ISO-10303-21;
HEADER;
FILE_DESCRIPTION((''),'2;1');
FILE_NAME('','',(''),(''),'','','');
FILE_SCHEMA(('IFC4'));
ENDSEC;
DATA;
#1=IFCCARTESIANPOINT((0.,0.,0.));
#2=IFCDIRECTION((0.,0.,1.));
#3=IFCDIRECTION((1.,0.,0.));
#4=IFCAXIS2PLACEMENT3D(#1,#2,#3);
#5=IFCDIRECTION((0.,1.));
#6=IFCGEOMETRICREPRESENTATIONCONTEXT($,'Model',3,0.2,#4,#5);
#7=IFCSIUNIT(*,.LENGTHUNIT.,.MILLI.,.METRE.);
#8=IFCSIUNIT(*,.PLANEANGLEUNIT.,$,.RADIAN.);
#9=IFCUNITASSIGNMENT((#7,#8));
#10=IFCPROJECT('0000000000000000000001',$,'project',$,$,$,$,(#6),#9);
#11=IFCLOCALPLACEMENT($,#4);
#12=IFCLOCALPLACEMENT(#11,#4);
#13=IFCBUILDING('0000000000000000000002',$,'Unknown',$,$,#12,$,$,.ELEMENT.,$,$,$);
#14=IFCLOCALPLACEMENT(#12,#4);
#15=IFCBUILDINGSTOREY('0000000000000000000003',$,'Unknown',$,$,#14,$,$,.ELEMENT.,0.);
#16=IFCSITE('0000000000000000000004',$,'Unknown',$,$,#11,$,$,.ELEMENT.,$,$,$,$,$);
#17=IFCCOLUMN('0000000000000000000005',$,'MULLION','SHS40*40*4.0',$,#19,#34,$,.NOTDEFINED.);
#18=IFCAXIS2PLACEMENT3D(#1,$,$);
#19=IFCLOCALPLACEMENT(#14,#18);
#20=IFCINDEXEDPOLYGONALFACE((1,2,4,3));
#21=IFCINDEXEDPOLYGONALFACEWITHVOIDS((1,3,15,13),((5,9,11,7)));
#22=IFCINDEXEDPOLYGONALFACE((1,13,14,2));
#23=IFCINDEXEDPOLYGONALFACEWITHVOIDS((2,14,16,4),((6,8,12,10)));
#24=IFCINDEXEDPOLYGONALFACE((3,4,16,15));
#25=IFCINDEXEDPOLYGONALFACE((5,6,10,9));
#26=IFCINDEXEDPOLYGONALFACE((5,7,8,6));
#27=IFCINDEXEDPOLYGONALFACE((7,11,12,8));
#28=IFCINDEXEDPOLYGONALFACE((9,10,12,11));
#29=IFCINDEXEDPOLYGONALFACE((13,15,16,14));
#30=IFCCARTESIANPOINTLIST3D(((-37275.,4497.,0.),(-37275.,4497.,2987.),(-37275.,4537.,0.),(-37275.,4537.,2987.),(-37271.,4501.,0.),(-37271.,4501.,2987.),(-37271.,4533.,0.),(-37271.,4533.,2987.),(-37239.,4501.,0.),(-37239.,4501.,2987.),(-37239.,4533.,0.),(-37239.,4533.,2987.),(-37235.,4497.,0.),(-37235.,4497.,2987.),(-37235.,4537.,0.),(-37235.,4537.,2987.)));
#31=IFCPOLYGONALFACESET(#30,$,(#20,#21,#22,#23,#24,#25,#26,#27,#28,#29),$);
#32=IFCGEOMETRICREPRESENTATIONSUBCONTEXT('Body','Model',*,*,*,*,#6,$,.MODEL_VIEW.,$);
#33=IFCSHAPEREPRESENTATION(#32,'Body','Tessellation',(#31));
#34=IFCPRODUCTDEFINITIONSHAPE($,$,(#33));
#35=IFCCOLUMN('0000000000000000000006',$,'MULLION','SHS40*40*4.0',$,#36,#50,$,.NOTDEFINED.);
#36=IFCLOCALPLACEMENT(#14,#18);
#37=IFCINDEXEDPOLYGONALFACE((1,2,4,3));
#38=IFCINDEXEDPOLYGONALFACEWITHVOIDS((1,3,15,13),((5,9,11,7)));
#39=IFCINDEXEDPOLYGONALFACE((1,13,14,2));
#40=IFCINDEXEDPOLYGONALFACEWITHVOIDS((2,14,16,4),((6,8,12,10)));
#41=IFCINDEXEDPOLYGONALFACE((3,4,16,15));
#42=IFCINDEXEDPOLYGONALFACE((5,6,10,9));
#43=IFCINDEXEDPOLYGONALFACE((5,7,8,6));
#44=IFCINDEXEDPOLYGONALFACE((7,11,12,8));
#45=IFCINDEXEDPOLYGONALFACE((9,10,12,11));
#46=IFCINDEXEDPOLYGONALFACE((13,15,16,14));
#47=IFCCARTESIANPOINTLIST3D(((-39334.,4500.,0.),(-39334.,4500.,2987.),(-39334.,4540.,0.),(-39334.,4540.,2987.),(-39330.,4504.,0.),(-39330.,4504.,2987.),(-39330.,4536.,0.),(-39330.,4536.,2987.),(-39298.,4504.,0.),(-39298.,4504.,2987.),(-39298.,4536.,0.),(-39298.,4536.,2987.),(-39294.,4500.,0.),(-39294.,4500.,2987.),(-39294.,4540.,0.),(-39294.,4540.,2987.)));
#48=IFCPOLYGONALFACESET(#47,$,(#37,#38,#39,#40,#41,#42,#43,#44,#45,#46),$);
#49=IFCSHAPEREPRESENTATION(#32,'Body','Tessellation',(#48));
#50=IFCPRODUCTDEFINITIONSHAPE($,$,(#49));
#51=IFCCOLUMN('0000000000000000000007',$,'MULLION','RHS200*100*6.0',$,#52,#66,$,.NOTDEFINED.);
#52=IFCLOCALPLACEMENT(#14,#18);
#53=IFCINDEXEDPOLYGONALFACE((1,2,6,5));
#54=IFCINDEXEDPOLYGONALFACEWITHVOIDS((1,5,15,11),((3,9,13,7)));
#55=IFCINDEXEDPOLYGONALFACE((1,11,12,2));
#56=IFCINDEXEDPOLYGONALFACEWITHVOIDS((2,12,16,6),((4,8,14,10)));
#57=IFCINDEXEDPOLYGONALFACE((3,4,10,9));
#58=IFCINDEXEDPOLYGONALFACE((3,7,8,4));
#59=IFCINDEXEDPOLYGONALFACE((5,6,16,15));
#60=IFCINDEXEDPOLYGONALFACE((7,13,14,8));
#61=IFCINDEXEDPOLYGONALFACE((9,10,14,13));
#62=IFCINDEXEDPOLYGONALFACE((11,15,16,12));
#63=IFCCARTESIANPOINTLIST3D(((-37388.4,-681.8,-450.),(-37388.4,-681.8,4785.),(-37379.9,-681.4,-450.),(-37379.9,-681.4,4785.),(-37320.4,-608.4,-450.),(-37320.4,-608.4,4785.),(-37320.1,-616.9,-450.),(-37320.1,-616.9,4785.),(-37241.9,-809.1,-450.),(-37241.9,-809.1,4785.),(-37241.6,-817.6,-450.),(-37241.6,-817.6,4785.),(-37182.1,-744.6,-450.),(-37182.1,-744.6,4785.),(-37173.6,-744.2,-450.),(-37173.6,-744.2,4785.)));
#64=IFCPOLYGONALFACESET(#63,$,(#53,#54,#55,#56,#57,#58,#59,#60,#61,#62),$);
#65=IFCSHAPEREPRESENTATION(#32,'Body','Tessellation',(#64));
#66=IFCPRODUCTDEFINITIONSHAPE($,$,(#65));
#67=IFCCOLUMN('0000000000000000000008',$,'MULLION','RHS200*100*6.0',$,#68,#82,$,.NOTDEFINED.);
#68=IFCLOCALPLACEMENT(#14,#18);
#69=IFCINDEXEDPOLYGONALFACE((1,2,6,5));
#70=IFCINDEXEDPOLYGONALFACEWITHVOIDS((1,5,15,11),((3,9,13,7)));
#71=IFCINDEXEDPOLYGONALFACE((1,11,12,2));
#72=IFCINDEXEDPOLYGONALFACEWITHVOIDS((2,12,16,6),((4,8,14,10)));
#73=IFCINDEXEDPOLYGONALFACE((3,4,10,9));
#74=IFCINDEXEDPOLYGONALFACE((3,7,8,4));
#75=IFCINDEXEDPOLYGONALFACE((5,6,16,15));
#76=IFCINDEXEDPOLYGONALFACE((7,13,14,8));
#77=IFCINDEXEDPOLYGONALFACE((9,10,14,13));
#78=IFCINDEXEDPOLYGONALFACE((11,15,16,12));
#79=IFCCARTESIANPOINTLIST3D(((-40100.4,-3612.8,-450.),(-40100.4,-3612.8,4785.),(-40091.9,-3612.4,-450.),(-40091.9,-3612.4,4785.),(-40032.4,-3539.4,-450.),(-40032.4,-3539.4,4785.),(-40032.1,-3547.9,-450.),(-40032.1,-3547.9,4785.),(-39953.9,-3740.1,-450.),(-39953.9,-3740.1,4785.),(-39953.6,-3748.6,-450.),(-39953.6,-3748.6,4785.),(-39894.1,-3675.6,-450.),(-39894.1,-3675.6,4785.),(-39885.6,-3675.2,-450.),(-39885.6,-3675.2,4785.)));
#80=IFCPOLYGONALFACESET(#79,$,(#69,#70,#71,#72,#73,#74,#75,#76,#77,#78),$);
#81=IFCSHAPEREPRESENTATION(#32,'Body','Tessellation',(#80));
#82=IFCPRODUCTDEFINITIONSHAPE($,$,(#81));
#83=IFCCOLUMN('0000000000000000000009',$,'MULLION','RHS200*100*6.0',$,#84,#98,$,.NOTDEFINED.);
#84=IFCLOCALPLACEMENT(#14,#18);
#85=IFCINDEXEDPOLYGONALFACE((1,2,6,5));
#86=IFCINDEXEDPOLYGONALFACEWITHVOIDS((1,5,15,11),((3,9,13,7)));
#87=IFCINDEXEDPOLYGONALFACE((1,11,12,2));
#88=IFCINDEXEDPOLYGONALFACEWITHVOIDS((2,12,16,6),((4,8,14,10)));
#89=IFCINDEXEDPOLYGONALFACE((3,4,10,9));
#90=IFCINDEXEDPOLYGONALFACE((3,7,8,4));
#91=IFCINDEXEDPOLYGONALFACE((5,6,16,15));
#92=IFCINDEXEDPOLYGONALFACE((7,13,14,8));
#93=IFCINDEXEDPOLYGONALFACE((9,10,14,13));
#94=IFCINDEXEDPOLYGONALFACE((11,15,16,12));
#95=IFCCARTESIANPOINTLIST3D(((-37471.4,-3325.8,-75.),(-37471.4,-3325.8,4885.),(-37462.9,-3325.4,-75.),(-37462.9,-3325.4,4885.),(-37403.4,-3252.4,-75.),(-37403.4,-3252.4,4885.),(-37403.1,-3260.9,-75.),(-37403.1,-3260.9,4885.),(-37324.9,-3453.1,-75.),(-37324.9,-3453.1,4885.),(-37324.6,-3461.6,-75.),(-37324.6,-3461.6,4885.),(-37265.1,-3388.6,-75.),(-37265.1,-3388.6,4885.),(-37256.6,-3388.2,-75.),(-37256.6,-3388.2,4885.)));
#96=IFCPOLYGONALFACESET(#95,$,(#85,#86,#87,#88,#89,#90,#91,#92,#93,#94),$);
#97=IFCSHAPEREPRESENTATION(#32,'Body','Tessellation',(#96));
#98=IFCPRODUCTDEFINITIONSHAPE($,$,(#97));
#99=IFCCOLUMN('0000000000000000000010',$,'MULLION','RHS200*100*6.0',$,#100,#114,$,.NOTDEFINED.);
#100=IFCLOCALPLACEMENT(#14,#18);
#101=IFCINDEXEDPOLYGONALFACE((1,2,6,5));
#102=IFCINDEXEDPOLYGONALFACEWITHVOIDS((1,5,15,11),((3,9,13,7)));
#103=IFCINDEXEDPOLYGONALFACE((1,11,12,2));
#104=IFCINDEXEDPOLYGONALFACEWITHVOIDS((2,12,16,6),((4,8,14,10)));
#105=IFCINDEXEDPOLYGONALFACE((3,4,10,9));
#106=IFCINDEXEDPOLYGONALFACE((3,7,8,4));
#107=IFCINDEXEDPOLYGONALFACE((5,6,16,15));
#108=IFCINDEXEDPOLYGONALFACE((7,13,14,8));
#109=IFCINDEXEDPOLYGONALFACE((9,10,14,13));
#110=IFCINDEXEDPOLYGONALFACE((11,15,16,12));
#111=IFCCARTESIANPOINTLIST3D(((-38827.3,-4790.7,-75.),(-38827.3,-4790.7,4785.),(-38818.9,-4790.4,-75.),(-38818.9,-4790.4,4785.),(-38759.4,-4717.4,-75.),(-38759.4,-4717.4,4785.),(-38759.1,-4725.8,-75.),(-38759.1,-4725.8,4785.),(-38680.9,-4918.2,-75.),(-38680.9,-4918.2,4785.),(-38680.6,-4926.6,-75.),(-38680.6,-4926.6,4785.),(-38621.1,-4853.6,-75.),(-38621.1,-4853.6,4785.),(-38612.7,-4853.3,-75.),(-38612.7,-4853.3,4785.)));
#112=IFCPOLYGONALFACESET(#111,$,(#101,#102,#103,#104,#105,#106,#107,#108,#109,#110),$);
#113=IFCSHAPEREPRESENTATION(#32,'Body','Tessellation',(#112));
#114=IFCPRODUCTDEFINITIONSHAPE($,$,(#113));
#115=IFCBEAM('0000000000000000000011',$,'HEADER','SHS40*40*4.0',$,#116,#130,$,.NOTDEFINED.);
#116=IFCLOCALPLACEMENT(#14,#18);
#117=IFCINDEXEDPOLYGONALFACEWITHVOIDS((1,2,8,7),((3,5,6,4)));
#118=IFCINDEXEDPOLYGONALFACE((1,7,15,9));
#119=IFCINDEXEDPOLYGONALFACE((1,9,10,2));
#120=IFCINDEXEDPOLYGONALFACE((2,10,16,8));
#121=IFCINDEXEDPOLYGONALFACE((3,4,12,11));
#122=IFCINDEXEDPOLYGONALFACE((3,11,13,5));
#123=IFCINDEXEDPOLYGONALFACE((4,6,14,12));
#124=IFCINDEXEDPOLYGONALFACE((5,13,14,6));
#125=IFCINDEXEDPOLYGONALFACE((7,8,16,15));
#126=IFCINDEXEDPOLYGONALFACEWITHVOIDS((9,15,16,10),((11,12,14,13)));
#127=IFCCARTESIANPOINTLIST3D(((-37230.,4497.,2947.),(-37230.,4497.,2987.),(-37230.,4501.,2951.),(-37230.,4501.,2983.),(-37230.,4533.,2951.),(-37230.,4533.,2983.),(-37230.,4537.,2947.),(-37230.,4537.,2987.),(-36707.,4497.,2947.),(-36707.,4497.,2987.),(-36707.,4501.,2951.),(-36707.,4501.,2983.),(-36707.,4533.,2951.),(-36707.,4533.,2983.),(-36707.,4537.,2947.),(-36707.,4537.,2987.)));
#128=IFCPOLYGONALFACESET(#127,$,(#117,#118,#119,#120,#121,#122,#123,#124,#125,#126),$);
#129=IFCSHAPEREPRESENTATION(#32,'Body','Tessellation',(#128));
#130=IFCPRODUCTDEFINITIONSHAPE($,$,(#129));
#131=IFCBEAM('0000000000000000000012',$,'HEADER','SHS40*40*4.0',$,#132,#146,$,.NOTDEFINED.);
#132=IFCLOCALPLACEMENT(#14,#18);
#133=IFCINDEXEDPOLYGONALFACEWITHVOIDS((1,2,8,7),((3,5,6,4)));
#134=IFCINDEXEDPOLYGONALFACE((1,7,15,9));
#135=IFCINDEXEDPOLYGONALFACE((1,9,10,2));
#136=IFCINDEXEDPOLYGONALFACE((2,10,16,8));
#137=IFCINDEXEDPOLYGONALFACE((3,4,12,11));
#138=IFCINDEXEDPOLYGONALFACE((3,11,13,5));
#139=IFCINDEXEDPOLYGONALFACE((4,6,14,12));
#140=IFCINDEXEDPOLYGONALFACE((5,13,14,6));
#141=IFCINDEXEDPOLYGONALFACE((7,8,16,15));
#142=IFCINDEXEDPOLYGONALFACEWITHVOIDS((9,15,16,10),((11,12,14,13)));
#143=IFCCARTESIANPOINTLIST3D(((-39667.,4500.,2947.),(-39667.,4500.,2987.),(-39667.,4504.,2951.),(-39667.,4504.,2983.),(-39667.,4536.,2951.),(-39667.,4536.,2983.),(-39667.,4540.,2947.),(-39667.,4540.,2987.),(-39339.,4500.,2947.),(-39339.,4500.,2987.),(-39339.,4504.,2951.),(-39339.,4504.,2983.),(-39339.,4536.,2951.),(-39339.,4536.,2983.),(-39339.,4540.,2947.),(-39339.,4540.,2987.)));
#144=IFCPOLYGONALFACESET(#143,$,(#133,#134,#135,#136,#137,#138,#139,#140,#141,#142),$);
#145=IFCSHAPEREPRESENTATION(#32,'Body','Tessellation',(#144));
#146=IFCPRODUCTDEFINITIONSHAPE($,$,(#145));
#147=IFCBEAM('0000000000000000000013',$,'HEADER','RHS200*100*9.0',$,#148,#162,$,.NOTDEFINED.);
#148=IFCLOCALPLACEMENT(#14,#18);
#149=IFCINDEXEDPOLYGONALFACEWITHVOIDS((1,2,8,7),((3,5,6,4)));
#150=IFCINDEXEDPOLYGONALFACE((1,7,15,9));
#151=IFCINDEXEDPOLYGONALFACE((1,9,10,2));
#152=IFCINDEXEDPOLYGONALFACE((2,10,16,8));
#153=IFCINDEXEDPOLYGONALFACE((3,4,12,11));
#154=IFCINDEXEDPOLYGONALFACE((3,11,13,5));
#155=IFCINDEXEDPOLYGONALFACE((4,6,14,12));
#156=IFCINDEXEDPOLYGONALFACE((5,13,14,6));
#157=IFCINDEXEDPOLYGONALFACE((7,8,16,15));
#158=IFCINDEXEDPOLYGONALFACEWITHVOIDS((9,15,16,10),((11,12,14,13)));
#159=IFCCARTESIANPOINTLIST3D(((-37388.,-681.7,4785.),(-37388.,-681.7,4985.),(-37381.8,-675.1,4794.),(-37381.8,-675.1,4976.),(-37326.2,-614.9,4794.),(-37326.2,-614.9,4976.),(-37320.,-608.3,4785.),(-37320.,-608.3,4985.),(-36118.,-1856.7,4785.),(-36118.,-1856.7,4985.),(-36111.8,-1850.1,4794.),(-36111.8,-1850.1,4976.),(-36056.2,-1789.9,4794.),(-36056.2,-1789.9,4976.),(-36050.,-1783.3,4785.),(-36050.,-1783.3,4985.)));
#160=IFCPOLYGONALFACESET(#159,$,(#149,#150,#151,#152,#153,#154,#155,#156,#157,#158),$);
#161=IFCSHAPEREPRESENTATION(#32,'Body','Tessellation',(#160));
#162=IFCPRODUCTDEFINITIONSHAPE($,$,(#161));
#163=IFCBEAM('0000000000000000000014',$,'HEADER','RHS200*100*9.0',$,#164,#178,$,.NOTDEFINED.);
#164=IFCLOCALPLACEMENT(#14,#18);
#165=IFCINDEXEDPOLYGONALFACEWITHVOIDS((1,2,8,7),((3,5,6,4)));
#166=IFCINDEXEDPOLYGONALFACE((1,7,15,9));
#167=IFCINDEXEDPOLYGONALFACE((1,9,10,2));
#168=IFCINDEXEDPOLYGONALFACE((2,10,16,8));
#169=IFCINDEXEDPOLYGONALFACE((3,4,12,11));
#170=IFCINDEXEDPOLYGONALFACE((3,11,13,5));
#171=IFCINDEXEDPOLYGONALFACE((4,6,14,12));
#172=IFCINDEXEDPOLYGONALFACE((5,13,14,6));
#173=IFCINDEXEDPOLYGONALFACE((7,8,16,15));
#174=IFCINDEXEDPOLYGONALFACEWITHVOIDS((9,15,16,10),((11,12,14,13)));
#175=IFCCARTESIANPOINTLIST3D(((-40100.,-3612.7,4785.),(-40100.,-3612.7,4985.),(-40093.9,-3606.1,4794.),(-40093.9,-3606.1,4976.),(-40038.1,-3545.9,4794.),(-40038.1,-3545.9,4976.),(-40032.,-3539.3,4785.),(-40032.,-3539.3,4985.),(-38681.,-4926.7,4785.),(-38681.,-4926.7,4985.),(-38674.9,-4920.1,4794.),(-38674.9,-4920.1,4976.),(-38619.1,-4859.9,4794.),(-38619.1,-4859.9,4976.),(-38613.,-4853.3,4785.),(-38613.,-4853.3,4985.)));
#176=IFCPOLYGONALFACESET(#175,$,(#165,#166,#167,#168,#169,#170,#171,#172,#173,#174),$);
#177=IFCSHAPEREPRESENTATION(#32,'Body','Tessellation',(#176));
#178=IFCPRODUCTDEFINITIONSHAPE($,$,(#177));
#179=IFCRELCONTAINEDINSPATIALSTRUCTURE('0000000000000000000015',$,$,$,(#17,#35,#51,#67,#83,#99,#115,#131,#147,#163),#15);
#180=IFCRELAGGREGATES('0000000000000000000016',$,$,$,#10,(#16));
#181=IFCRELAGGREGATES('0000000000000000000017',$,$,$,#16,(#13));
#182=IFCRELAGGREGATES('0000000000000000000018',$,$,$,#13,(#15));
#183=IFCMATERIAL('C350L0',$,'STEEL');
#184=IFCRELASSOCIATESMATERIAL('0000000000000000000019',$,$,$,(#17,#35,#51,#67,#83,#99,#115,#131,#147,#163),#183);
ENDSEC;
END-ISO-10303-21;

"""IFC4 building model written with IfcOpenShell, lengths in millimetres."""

from ifc_helpers import new_model, si_unit, direction, frame, origin_with_axes, place, context, subcontext, project, spatial, line, indexed_curve, outline, extrude, material, element, save


model = new_model("IFC4")

# Units and contexts
model_context = context("Model", 3, precision=0.2, world=origin_with_axes(), true_north=direction((0.0, 1.0)))
body_context = subcontext(model_context, "Body", "Model", "MODEL_VIEW")
ifc_project = project(units=[si_unit("LENGTHUNIT", "METRE", prefix="MILLI"), si_unit("PLANEANGLEUNIT", "RADIAN")], contexts=[model_context])

# Site, building, storey
site_placement = place(None, origin_with_axes())
site = spatial("IfcSite", under=ifc_project, at=site_placement, Name="Unknown", CompositionType="ELEMENT")
building_placement = place(site_placement, origin_with_axes())
building = spatial("IfcBuilding", under=site, at=building_placement, Name="Unknown", CompositionType="ELEMENT")
storey_placement = place(building_placement, origin_with_axes())
storey = spatial("IfcBuildingStorey", under=building, at=storey_placement, Name="Unknown", CompositionType="ELEMENT", Elevation=0.0)

# Columns
ifc_material_1 = material(Name="C350L0", Category="STEEL")
for number, where, z_axis, x_axis, name in (
    (1, (-37255.0, 4517.0, 0.0), (0.000017, -1.0, 0.0), (0.0, 0.0, 1.0), "MULLION"),
    (2, (-39314.0, 4520.0, 0.0), (0.000017, -1.0, 0.0), (0.0, 0.0, 1.0), "MULLION"),
):
    element("IfcColumn", number, at=place(storey_placement, frame(where, z_axis=z_axis, x_axis=x_axis)), inside=storey, material=ifc_material_1, Name=name, Description="SHS40*40*4.0", PredefinedType="NOTDEFINED", context=body_context, shape_type="SolidModel", body=[
        extrude(outline(indexed_curve([(-20.0, -20.0), (20.0, -20.0), (20.0, 20.0), (-20.0, 20.0)], segments=[line(1, 2, 3, 4, 1)]), holes=[indexed_curve([(-16.0, -16.0), (-16.0, 16.0), (16.0, 16.0), (16.0, -16.0)], segments=[line(1, 2, 3, 4, 1)])]), frame((0.0, 0.0, 0.0), z_axis=(-1.0, 0.0, 0.0), x_axis=(0.0, 0.0, 1.0)), (0.0, 0.0, -1.0), 2987.0),
    ])
for number, where, z_axis, x_axis, name in (
    (3, (-37281.0, -713.0, -450.0), (0.679313, 0.733848, 0.0), (0.0, 0.0, 1.0), "MULLION"),
    (4, (-39993.0, -3644.0, -450.0), (0.679313, 0.733848, 0.0), (0.0, 0.0, 1.0), "MULLION"),
):
    element("IfcColumn", number, at=place(storey_placement, frame(where, z_axis=z_axis, x_axis=x_axis)), inside=storey, material=ifc_material_1, Name=name, Description="RHS200*100*6.0", PredefinedType="NOTDEFINED", context=body_context, shape_type="SolidModel", body=[
        extrude(outline(indexed_curve([(-50.0, -100.0), (50.0, -100.0), (50.0, 100.0), (-50.0, 100.0)], segments=[line(1, 2, 3, 4, 1)]), holes=[indexed_curve([(-44.0, -94.0), (-44.0, 94.0), (44.0, 94.0), (44.0, -94.0)], segments=[line(1, 2, 3, 4, 1)])]), frame((0.0, 0.0, 0.0), z_axis=(-1.0, 0.0, 0.0), x_axis=(0.0, 0.0, 1.0)), (0.0, 0.0, -1.0), 5235.0),
    ])
column_1_placement = place(storey_placement, frame((-37364.0, -3357.0, -75.0), z_axis=(0.679313, 0.733848, 0.0), x_axis=(0.0, 0.0, 1.0)))
element("IfcColumn", 5, at=column_1_placement, inside=storey, material=ifc_material_1, Name="MULLION", Description="RHS200*100*6.0", PredefinedType="NOTDEFINED", context=body_context, shape_type="SolidModel", body=[
    extrude(outline(indexed_curve([(-50.0, -100.0), (50.0, -100.0), (50.0, 100.0), (-50.0, 100.0)], segments=[line(1, 2, 3, 4, 1)]), holes=[indexed_curve([(-44.0, -94.0), (-44.0, 94.0), (44.0, 94.0), (44.0, -94.0)], segments=[line(1, 2, 3, 4, 1)])]), frame((0.0, 0.0, 0.0), z_axis=(-1.0, 0.0, 0.0), x_axis=(0.0, 0.0, 1.0)), (0.0, 0.0, -1.0), 4960.0),
])
column_2_placement = place(storey_placement, frame((-38720.0, -4822.0, -75.0), z_axis=(0.679441, 0.73373, 0.0), x_axis=(0.0, 0.0, 1.0)))
element("IfcColumn", 6, at=column_2_placement, inside=storey, material=ifc_material_1, Name="MULLION", Description="RHS200*100*6.0", PredefinedType="NOTDEFINED", context=body_context, shape_type="SolidModel", body=[
    extrude(outline(indexed_curve([(-50.0, -100.0), (50.0, -100.0), (50.0, 100.0), (-50.0, 100.0)], segments=[line(1, 2, 3, 4, 1)]), holes=[indexed_curve([(-44.0, -94.0), (-44.0, 94.0), (44.0, 94.0), (44.0, -94.0)], segments=[line(1, 2, 3, 4, 1)])]), frame((0.0, 0.0, 0.0), z_axis=(-1.0, 0.0, 0.0), x_axis=(0.0, 0.0, 1.0)), (0.0, 0.0, -1.0), 4860.0),
])

# Beams
beam_1_placement = place(storey_placement, frame((-37230.0, 4517.0, 2967.0), z_axis=(0.0, 0.0, 1.0), x_axis=(1.0, 0.0, 0.0)))
element("IfcBeam", 7, at=beam_1_placement, inside=storey, material=ifc_material_1, Name="HEADER", Description="SHS40*40*4.0", PredefinedType="NOTDEFINED", context=body_context, shape_type="SolidModel", body=[
    extrude(outline(indexed_curve([(-20.0, -20.0), (20.0, -20.0), (20.0, 20.0), (-20.0, 20.0)], segments=[line(1, 2, 3, 4, 1)]), holes=[indexed_curve([(-16.0, -16.0), (-16.0, 16.0), (16.0, 16.0), (16.0, -16.0)], segments=[line(1, 2, 3, 4, 1)])]), frame((0.0, 0.0, 0.0), z_axis=(-1.0, 0.0, 0.0), x_axis=(0.0, 0.0, 1.0)), (0.0, 0.0, -1.0), 523.0),
])
beam_2_placement = place(storey_placement, frame((-39667.0, 4520.0, 2967.0), z_axis=(0.0, 0.0, 1.0), x_axis=(1.0, 0.0, 0.0)))
element("IfcBeam", 8, at=beam_2_placement, inside=storey, material=ifc_material_1, Name="HEADER", Description="SHS40*40*4.0", PredefinedType="NOTDEFINED", context=body_context, shape_type="SolidModel", body=[
    extrude(outline(indexed_curve([(-20.0, -20.0), (20.0, -20.0), (20.0, 20.0), (-20.0, 20.0)], segments=[line(1, 2, 3, 4, 1)]), holes=[indexed_curve([(-16.0, -16.0), (-16.0, 16.0), (16.0, 16.0), (16.0, -16.0)], segments=[line(1, 2, 3, 4, 1)])]), frame((0.0, 0.0, 0.0), z_axis=(-1.0, 0.0, 0.0), x_axis=(0.0, 0.0, 1.0)), (0.0, 0.0, -1.0), 328.0),
])
beam_3_placement = place(storey_placement, frame((-37354.0, -645.0, 4885.0), z_axis=(-0.67912, -0.734027, 0.0), x_axis=(0.734027, -0.67912, 0.0)))
element("IfcBeam", 9, at=beam_3_placement, inside=storey, material=ifc_material_1, Name="HEADER", Description="RHS200*100*9.0", PredefinedType="NOTDEFINED", context=body_context, shape_type="SolidModel", body=[
    extrude(outline(indexed_curve([(-50.0, -100.0), (50.0, -100.0), (50.0, 100.0), (-50.0, 100.0)], segments=[line(1, 2, 3, 4, 1)]), holes=[indexed_curve([(-41.0, -91.0), (-41.0, 91.0), (41.0, 91.0), (41.0, -91.0)], segments=[line(1, 2, 3, 4, 1)])]), frame((0.0, 0.0, 0.0), z_axis=(-1.0, 0.0, 0.0), x_axis=(0.0, 0.0, 1.0)), (0.0, 0.0, -1.0), 1730.2),
])
beam_4_placement = place(storey_placement, frame((-40066.0, -3576.0, 4885.0), z_axis=(-0.679439, -0.733732, 0.0), x_axis=(0.733732, -0.679439, 0.0)))
element("IfcBeam", 10, at=beam_4_placement, inside=storey, material=ifc_material_1, Name="HEADER", Description="RHS200*100*9.0", PredefinedType="NOTDEFINED", context=body_context, shape_type="SolidModel", body=[
    extrude(outline(indexed_curve([(-50.0, -100.0), (50.0, -100.0), (50.0, 100.0), (-50.0, 100.0)], segments=[line(1, 2, 3, 4, 1)]), holes=[indexed_curve([(-41.0, -91.0), (-41.0, 91.0), (41.0, 91.0), (41.0, -91.0)], segments=[line(1, 2, 3, 4, 1)])]), frame((0.0, 0.0, 0.0), z_axis=(-1.0, 0.0, 0.0), x_axis=(0.0, 0.0, 1.0)), (0.0, 0.0, -1.0), 1933.9),
])

save(model, "model.ifc")
